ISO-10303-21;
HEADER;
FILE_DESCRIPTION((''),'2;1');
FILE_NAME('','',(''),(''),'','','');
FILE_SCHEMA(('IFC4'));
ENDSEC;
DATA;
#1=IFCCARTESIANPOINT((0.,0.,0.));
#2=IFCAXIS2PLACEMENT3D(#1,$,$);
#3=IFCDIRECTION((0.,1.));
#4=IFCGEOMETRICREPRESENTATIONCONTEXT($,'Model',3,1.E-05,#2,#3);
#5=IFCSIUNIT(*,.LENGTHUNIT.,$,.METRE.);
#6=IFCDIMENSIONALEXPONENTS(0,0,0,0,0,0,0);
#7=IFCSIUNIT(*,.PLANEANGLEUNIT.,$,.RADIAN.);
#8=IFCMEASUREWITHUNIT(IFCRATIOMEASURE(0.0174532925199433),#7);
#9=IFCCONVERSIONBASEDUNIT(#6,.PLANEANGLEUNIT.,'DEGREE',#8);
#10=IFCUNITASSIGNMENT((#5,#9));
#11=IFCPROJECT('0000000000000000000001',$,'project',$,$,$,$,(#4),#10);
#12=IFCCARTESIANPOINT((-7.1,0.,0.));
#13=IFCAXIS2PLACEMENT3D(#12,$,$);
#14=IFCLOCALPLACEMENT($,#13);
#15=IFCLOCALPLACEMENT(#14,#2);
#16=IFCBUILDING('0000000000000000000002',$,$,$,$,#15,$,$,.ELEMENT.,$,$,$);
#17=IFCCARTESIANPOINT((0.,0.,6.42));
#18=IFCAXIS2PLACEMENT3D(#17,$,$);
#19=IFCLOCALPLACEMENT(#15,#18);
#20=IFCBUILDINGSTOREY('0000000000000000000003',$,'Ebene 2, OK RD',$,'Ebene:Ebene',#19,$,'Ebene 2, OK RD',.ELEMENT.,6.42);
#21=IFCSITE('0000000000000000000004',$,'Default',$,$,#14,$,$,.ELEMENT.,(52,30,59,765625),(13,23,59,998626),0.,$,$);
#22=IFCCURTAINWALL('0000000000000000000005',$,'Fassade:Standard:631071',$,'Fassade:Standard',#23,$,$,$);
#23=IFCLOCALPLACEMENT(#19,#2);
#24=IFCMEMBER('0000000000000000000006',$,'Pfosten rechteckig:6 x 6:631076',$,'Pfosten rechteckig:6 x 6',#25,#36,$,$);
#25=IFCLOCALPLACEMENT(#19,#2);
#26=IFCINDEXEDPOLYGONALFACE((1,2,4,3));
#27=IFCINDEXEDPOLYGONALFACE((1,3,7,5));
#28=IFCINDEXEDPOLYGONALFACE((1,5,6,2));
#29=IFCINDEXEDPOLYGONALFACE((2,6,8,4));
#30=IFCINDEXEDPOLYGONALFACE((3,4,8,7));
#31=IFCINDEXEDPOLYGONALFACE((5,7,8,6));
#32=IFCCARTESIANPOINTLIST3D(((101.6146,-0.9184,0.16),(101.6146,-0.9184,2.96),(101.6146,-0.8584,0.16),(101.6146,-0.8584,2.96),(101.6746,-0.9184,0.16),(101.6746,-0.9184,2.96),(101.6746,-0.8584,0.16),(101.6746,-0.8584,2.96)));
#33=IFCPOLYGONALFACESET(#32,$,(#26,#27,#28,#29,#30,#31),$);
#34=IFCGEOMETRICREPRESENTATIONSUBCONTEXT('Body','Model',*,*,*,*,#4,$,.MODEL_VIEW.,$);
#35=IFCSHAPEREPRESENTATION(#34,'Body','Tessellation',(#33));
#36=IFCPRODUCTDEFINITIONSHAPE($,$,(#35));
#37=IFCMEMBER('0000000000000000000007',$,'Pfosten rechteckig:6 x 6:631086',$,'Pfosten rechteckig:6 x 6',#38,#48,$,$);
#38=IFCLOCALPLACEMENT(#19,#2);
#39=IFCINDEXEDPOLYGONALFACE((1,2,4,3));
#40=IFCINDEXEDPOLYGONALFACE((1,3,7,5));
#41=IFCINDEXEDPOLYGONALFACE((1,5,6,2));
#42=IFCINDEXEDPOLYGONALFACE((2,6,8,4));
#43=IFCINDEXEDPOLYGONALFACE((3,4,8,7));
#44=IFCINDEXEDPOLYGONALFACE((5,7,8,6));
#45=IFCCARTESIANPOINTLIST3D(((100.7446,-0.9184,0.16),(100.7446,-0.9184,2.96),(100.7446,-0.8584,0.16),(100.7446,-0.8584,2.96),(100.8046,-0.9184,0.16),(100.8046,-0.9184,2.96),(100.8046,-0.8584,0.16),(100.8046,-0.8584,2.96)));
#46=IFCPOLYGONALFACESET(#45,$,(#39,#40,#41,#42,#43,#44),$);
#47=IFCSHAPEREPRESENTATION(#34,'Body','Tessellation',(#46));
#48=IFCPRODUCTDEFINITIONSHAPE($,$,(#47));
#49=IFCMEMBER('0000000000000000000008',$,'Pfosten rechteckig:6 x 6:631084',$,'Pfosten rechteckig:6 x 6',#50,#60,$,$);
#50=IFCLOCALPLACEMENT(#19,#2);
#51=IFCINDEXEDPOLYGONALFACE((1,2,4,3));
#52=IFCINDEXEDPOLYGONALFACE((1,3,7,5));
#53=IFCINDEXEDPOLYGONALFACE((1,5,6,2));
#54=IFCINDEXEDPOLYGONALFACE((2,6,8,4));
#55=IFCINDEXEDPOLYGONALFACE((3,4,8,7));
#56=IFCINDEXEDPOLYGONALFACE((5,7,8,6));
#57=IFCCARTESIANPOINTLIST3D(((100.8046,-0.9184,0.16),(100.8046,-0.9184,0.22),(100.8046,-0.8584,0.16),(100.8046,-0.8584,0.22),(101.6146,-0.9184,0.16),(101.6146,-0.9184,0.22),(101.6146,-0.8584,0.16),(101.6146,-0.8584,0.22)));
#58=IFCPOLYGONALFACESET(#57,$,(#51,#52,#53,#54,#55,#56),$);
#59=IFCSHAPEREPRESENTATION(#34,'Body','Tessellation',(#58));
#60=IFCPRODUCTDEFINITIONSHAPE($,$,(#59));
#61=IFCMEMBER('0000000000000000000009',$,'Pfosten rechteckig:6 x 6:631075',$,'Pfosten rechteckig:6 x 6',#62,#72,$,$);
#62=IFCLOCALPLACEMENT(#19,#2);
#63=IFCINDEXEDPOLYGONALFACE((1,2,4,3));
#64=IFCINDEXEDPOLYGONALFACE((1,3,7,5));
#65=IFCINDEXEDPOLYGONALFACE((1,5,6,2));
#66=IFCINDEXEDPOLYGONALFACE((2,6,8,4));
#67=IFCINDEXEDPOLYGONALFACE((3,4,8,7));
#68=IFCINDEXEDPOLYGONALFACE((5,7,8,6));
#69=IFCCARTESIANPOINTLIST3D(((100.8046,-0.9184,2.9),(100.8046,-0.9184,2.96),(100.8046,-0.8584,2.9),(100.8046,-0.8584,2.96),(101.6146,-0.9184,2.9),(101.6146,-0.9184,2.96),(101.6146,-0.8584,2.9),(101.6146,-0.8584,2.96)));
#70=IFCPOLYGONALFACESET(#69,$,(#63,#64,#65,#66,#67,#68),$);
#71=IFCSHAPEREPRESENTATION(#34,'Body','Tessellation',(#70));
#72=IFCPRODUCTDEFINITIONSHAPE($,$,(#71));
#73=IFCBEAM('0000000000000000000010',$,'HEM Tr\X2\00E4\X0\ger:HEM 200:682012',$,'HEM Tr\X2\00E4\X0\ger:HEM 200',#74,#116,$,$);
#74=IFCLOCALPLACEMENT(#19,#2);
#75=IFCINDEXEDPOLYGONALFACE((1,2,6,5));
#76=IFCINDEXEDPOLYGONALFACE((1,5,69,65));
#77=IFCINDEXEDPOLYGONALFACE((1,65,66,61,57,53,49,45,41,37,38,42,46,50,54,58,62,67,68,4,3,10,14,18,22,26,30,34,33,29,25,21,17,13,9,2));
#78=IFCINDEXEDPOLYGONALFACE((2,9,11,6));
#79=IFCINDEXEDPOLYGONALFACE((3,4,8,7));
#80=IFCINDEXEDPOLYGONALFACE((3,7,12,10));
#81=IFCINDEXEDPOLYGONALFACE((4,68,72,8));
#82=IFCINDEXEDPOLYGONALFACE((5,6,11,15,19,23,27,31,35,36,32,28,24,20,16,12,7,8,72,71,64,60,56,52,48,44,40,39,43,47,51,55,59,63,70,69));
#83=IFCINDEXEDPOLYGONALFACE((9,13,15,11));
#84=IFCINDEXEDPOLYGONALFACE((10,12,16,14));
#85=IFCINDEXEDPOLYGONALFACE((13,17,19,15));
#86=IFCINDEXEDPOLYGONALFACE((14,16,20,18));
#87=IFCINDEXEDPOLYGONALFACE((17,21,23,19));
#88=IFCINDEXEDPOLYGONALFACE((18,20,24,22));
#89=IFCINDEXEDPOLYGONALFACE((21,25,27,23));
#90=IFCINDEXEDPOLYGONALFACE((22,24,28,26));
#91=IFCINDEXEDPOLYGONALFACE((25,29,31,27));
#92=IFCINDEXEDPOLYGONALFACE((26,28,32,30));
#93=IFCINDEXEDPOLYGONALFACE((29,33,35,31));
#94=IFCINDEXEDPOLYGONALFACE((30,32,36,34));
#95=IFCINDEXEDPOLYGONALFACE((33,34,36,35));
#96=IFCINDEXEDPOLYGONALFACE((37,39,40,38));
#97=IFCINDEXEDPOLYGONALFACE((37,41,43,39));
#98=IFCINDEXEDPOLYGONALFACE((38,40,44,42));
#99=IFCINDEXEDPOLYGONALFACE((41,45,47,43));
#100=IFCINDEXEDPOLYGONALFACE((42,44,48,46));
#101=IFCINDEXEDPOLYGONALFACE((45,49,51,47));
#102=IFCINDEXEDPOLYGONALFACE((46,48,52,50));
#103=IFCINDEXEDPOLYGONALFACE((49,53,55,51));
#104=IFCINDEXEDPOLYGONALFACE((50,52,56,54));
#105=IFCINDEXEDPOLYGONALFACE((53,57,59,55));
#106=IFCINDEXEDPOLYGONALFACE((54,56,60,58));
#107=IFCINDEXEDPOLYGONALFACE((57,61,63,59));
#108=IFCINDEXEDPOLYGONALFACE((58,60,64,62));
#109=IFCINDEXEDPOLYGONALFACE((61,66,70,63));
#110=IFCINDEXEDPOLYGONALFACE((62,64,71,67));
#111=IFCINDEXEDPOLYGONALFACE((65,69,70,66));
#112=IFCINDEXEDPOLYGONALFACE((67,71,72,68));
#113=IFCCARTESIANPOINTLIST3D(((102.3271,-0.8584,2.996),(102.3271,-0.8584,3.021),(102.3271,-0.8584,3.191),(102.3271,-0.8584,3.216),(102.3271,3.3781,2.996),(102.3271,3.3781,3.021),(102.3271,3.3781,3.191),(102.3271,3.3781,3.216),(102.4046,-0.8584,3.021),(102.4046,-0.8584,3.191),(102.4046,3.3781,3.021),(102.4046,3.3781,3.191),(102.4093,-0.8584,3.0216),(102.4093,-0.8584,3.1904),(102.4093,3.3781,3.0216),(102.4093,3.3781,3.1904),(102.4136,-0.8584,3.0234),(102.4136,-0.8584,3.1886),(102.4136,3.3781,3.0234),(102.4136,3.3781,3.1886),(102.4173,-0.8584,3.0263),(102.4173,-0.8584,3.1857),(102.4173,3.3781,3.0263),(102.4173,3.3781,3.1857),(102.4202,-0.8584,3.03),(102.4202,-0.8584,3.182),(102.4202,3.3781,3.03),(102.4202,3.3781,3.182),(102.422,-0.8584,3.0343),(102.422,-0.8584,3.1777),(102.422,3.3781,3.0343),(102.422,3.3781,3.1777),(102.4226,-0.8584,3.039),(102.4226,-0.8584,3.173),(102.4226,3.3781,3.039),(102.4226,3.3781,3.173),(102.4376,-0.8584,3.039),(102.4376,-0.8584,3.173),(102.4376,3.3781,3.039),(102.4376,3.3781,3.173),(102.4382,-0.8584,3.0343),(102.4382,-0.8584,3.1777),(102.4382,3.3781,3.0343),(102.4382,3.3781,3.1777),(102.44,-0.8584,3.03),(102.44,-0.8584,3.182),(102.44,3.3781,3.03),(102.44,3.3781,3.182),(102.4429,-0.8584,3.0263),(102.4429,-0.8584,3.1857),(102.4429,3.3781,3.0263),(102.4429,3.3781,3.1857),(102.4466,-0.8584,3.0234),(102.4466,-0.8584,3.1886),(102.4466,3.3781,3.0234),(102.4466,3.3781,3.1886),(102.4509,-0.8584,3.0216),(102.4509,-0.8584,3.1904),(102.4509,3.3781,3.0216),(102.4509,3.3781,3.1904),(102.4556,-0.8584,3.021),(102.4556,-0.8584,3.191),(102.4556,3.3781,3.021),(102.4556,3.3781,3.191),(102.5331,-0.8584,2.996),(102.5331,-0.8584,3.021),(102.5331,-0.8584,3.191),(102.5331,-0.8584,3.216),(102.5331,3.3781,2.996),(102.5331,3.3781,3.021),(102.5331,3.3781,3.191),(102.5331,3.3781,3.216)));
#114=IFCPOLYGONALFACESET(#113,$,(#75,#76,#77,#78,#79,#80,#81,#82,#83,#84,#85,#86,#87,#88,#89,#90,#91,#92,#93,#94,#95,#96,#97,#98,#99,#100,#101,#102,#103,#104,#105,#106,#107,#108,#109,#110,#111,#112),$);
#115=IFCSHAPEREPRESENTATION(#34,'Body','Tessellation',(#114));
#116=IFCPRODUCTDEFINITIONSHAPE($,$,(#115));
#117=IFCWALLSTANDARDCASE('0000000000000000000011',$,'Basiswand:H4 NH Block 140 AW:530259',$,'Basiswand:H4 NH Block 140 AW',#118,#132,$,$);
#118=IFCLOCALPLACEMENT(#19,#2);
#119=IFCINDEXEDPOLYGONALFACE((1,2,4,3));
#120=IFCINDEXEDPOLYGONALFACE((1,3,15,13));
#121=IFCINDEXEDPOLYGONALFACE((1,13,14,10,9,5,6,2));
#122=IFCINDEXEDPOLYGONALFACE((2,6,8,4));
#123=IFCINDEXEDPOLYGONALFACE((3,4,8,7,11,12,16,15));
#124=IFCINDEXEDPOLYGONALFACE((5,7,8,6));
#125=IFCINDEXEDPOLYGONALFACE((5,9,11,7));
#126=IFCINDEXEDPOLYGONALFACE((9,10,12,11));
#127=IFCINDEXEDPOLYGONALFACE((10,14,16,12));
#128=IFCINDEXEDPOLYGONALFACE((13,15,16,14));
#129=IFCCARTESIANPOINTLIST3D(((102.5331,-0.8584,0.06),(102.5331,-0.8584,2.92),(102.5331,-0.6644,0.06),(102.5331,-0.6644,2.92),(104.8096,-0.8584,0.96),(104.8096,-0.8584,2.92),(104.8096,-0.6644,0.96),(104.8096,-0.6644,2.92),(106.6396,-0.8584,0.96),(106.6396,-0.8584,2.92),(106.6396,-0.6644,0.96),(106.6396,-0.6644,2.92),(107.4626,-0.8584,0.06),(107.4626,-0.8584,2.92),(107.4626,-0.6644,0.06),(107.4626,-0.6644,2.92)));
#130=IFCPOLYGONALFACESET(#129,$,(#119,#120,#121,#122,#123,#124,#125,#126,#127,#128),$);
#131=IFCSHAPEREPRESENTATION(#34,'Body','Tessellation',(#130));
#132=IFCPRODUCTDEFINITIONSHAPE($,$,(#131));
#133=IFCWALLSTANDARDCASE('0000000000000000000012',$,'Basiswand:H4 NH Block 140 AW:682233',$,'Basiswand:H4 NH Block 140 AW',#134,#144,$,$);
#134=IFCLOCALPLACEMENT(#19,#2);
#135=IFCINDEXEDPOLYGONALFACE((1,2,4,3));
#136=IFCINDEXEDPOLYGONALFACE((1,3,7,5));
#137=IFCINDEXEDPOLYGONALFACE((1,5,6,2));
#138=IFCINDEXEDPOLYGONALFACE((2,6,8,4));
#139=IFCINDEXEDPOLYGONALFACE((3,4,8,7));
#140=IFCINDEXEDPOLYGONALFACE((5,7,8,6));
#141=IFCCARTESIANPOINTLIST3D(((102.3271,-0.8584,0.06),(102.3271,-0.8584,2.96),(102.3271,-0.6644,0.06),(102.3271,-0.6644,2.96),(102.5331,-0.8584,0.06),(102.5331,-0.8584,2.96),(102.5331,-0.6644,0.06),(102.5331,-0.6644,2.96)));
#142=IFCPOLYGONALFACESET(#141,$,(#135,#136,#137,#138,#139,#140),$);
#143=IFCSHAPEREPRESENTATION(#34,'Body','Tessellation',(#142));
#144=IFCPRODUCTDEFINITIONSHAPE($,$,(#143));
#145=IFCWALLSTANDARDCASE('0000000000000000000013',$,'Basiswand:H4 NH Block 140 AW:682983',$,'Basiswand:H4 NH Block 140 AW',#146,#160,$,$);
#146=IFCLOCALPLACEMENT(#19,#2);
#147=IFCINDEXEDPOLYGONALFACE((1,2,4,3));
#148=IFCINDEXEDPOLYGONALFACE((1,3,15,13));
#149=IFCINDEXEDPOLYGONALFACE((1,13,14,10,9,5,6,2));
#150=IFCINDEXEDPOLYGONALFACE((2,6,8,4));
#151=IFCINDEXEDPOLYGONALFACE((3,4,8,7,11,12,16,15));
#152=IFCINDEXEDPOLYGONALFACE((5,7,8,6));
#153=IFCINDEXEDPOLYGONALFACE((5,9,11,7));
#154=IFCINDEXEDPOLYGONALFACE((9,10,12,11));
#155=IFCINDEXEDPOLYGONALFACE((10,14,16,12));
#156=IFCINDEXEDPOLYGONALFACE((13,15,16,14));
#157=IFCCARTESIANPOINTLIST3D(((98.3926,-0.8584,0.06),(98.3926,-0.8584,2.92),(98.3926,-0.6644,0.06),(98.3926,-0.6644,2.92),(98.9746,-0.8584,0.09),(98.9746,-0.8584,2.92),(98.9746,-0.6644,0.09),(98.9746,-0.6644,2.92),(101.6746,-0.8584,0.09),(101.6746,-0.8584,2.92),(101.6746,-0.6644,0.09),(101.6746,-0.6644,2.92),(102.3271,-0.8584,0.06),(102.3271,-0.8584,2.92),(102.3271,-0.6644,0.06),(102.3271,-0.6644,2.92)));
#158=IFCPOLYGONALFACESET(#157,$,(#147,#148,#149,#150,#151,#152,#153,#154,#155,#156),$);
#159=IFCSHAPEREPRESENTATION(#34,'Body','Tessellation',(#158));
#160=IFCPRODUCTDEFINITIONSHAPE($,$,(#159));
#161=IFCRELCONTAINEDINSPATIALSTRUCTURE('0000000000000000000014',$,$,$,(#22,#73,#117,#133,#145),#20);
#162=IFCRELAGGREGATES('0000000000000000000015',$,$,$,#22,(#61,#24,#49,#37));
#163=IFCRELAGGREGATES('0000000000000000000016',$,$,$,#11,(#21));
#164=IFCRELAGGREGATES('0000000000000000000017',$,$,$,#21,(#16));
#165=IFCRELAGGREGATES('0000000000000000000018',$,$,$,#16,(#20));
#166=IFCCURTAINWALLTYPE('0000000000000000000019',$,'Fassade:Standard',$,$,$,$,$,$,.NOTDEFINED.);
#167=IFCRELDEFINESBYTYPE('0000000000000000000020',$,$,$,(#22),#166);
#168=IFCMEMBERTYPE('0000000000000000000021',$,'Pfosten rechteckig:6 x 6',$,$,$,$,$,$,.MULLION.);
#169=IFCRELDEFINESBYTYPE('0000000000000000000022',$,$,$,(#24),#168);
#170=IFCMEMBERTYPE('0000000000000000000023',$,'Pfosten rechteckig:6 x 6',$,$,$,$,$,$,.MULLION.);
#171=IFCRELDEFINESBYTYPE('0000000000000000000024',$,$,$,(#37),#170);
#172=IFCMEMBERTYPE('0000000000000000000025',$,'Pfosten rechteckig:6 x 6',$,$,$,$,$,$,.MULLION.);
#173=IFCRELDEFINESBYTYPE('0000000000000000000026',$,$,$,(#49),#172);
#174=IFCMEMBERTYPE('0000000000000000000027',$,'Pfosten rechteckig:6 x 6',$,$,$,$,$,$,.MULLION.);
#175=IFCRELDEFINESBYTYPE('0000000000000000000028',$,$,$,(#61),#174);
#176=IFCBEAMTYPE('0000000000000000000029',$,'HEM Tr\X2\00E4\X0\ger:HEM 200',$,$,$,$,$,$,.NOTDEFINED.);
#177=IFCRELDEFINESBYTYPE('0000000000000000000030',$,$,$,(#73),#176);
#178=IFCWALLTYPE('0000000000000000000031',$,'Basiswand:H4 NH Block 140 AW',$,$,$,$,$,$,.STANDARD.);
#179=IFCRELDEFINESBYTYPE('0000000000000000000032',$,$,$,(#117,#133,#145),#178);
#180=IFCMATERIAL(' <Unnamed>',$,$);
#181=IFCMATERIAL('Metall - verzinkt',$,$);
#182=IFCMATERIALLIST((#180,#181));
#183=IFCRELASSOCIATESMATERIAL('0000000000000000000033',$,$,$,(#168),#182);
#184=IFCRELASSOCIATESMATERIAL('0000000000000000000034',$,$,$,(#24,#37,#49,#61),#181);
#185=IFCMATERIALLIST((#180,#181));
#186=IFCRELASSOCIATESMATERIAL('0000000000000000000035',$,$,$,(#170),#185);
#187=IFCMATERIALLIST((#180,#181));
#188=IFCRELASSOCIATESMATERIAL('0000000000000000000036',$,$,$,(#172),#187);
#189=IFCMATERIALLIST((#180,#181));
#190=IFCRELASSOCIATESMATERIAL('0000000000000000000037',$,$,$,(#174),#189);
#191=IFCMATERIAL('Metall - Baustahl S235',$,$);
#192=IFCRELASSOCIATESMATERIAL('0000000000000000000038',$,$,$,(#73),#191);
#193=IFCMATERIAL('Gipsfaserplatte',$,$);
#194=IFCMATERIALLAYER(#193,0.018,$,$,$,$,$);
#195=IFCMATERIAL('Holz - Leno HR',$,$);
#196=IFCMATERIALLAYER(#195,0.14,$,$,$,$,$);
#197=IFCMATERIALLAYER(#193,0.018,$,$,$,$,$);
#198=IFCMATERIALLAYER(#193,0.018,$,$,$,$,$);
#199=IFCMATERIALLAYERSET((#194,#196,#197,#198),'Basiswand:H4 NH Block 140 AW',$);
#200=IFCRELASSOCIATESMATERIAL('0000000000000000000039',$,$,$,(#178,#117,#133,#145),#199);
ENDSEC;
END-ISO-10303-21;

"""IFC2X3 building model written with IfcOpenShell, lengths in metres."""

from ifc_helpers import new_model, entity, si_unit, converted_unit, direction, frame, frame_2d, origin, origin_2d_with_axis, place, context, subcontext, project, spatial, rectangle, i_section, extrude, source, transform, mapped, material, material_list, layer, layer_set, layer_usage, type_object, type_shapes, element, aggregate, save


model = new_model("IFC2X3")

# Units and contexts
model_context = context("Model", 3, precision=1e-05, world=origin(), true_north=direction((0.0, 1.0)))
body_context = subcontext(model_context, "Body", "Model", "MODEL_VIEW")
ifc_project = project(units=[si_unit("LENGTHUNIT", "METRE"), converted_unit("PLANEANGLEUNIT", "DEGREE", entity("IfcRatioMeasure", 0.0174532925199433), si_unit("PLANEANGLEUNIT", "RADIAN"), dimensions=[0, 0, 0, 0, 0, 0, 0])], contexts=[model_context])

# Site, building, storey
site_placement = place(None, frame((-7.1, 0.0, 0.0)))
site = spatial("IfcSite", under=ifc_project, at=site_placement, Name="Default", CompositionType="ELEMENT", RefLatitude=(52, 30, 59, 765625), RefLongitude=(13, 23, 59, 998626), RefElevation=0.0)
building_placement = place(site_placement, origin())
building = spatial("IfcBuilding", under=site, at=building_placement, CompositionType="ELEMENT")
storey_placement = place(building_placement, frame((0.0, 0.0, 6.42)))
storey = spatial("IfcBuildingStorey", under=building, at=storey_placement, Name="Ebene 2, OK RD", ObjectType="Ebene:Ebene", LongName="Ebene 2, OK RD", CompositionType="ELEMENT", Elevation=6.42)

# Curtain wall, members
curtain_wall_type = type_object("IfcCurtainWallType", Name="Fassade:Standard", PredefinedType="NOTDEFINED")
curtain_wall_placement = place(storey_placement, frame((0.0, 0.0, -6.42)))
curtain_wall = element("IfcCurtainWall", 1, at=curtain_wall_placement, inside=storey, type_object=curtain_wall_type, Name="Fassade:Standard:631071", ObjectType="Fassade:Standard")
ifc_material_1 = material(Name="Metall - verzinkt")
ifc_material_2 = material(Name=" <Unnamed>")
ifc_material_list_1 = material_list([ifc_material_2, ifc_material_1])
member_type_1 = type_object("IfcMemberType", Name="Pfosten rechteckig:6 x 6", PredefinedType="MULLION", material=ifc_material_list_1)
shared_shape_1 = source(origin(), body_context, "Body", "SweptSolid", [
    extrude(rectangle(XDim=0.06, YDim=0.06, at=origin_2d_with_axis()), frame((-0.03, 0.0, -2.8), z_axis=(0.0, 0.0, 1.0), x_axis=(0.0, -1.0, 0.0)), (0.0, 0.0, 1.0), 2.8),
])
type_shapes(member_type_1, [shared_shape_1])
placement = place(building_placement, frame((0.0, 0.0, 3.26)))
member_1_placement = place(placement, frame((101.6746, -0.8884, 3.32), z_axis=(0.0, 0.0, -1.0), x_axis=(1.0, 0.0, 0.0)))
member_1 = element("IfcMember", 2, at=member_1_placement, type_object=member_type_1, material=ifc_material_1, Name="Pfosten rechteckig:6 x 6:631076", ObjectType="Pfosten rechteckig:6 x 6", context=body_context, shape_type="MappedRepresentation", body=[
    mapped(shared_shape_1, transform((0.0, 0.0, 0.0), scale=1.0)),
])
ifc_material_list_2 = material_list([ifc_material_2, ifc_material_1])
member_type_2 = type_object("IfcMemberType", Name="Pfosten rechteckig:6 x 6", PredefinedType="MULLION", material=ifc_material_list_2)
shared_shape_2 = source(origin(), body_context, "Body", "SweptSolid", [
    extrude(rectangle(XDim=0.06, YDim=0.06, at=origin_2d_with_axis()), frame((0.0, 0.0, -2.8), z_axis=(0.0, 0.0, 1.0), x_axis=(0.0, -1.0, 0.0)), (0.0, 0.0, 1.0), 2.8),
])
type_shapes(member_type_2, [shared_shape_2])
member_2_placement = place(placement, frame((100.7746, -0.8884, 3.32), z_axis=(0.0, 0.0, -1.0), x_axis=(1.0, 0.0, 0.0)))
member_2 = element("IfcMember", 3, at=member_2_placement, type_object=member_type_2, material=ifc_material_1, Name="Pfosten rechteckig:6 x 6:631086", ObjectType="Pfosten rechteckig:6 x 6", context=body_context, shape_type="MappedRepresentation", body=[
    mapped(shared_shape_2, transform((0.0, 0.0, 0.0), scale=1.0)),
])
ifc_material_list_3 = material_list([ifc_material_2, ifc_material_1])
member_type_3 = type_object("IfcMemberType", Name="Pfosten rechteckig:6 x 6", PredefinedType="MULLION", material=ifc_material_list_3)
shared_shape_3 = source(origin(), body_context, "Body", "SweptSolid", [
    extrude(rectangle(XDim=0.06, YDim=0.06, at=origin_2d_with_axis()), frame((-0.03, 0.0, -0.81), z_axis=(0.0, 0.0, 1.0), x_axis=(0.0, -1.0, 0.0)), (0.0, 0.0, 1.0), 0.81),
])
type_shapes(member_type_3, [shared_shape_3])
member_3_placement = place(placement, frame((100.8046, -0.8884, 3.32), z_axis=(-1.0, 0.0, 0.0), x_axis=(0.0, 0.0, -1.0)))
member_3 = element("IfcMember", 4, at=member_3_placement, type_object=member_type_3, material=ifc_material_1, Name="Pfosten rechteckig:6 x 6:631084", ObjectType="Pfosten rechteckig:6 x 6", context=body_context, shape_type="MappedRepresentation", body=[
    mapped(shared_shape_3, transform((0.0, 0.0, 0.0), scale=1.0)),
])
ifc_material_list_4 = material_list([ifc_material_2, ifc_material_1])
member_type_4 = type_object("IfcMemberType", Name="Pfosten rechteckig:6 x 6", PredefinedType="MULLION", material=ifc_material_list_4)
shared_shape_4 = source(origin(), body_context, "Body", "SweptSolid", [
    extrude(rectangle(XDim=0.06, YDim=0.06, at=origin_2d_with_axis()), frame((-0.03, 0.0, -0.81), z_axis=(0.0, 0.0, 1.0), x_axis=(0.0, -1.0, 0.0)), (0.0, 0.0, 1.0), 0.81),
])
type_shapes(member_type_4, [shared_shape_4])
member_4_placement = place(placement, frame((101.6146, -0.8884, 6.12), z_axis=(1.0, 0.0, 0.0), x_axis=(0.0, 0.0, 1.0)))
member_4 = element("IfcMember", 5, at=member_4_placement, type_object=member_type_4, material=ifc_material_1, Name="Pfosten rechteckig:6 x 6:631075", ObjectType="Pfosten rechteckig:6 x 6", context=body_context, shape_type="MappedRepresentation", body=[
    mapped(shared_shape_4, transform((0.0, 0.0, 0.0), scale=1.0)),
])

# Beam
ifc_material_3 = material(Name="Metall - Baustahl S235")
beam_type = type_object("IfcBeamType", Name="HEM Träger:HEM 200", PredefinedType="NOTDEFINED")
beam_placement = place(storey_placement, frame((102.4301, -0.8404, 2.996), z_axis=(0.0, 0.0, 1.0), x_axis=(0.0, 1.0, 0.0)))
element("IfcBeam", 6, at=beam_placement, inside=storey, type_object=beam_type, material=ifc_material_3, Name="HEM Träger:HEM 200:682012", ObjectType="HEM Träger:HEM 200", context=body_context, shape_type="SweptSolid", body=[
    extrude(i_section(OverallWidth=0.206, OverallDepth=0.22, WebThickness=0.015, FlangeThickness=0.025, FilletRadius=0.018, at=frame_2d((0.0, 0.0), x_axis=(0.0, 1.0))), frame((-0.018, 0.0, 0.11), z_axis=(1.0, 0.0, 0.0), x_axis=(0.0, 0.0, -1.0)), (0.0, 0.0, 1.0), 4.2365),
])

aggregate(curtain_wall, [member_4, member_1, member_3, member_2])

# Wall, opening
ifc_material_4 = material(Name="Gipsfaserplatte")
ifc_layer_1 = layer(ifc_material_4, 0.018)
ifc_material_5 = material(Name="Holz - Leno HR")
ifc_layer_2 = layer(ifc_material_5, 0.14)
ifc_layer_3 = layer(ifc_material_4, 0.018)
ifc_layer_4 = layer(ifc_material_4, 0.018)
ifc_layer_set_1 = layer_set([ifc_layer_1, ifc_layer_2, ifc_layer_3, ifc_layer_4], Name="Basiswand:H4 NH Block 140 AW")
ifc_layer_usage_1 = layer_usage(ifc_layer_set_1, "AXIS2", "NEGATIVE", 0.097)
wall_type_1 = type_object("IfcWallType", Name="Basiswand:H4 NH Block 140 AW", PredefinedType="STANDARD", material=ifc_layer_set_1)
wall_1_placement = place(storey_placement, frame((107.4626, -0.7614, 0.06), z_axis=(0.0, 0.0, 1.0), x_axis=(-1.0, 0.0, 0.0)))
wall_1 = element("IfcWallStandardCase", 7, at=wall_1_placement, inside=storey, type_object=wall_type_1, material=ifc_layer_usage_1, Name="Basiswand:H4 NH Block 140 AW:530259", ObjectType="Basiswand:H4 NH Block 140 AW", context=body_context, shape_type="SweptSolid", body=[
    extrude(rectangle(XDim=4.9295, YDim=0.194, at=frame_2d((2.4648, 0.0), x_axis=(-1.0, 0.0))), origin(), (0.0, 0.0, 1.0), 2.86),
])
opening_1_placement = place(wall_1_placement, origin())
element("IfcOpeningElement", 8, at=opening_1_placement, cuts=wall_1, ObjectType="Opening", context=body_context, shape_type="SweptSolid", body=[
    extrude(rectangle(XDim=2.0, YDim=1.83, at=frame_2d((0.0, 0.0), x_axis=(1.0, 0.0))), frame((1.738, -0.097, 1.9), z_axis=(0.0, 1.0, 0.0), x_axis=(0.0, 0.0, -1.0)), (0.0, 0.0, 1.0), 0.194),
])

# Wall
ifc_layer_usage_2 = layer_usage(ifc_layer_set_1, "AXIS2", "NEGATIVE", 0.097)
wall_2_placement = place(storey_placement, frame((102.5331, -0.7614, 0.06), z_axis=(0.0, 0.0, 1.0), x_axis=(-1.0, 0.0, 0.0)))
element("IfcWallStandardCase", 9, at=wall_2_placement, inside=storey, type_object=wall_type_1, material=ifc_layer_usage_2, Name="Basiswand:H4 NH Block 140 AW:682233", ObjectType="Basiswand:H4 NH Block 140 AW", context=body_context, shape_type="SweptSolid", body=[
    extrude(rectangle(XDim=0.206, YDim=0.194, at=frame_2d((0.103, 0.0), x_axis=(-1.0, 0.0))), origin(), (0.0, 0.0, 1.0), 2.9),
])

# Wall, opening
ifc_layer_usage_3 = layer_usage(ifc_layer_set_1, "AXIS2", "NEGATIVE", 0.097)
wall_3_placement = place(storey_placement, frame((102.3271, -0.7614, 0.06), z_axis=(0.0, 0.0, 1.0), x_axis=(-1.0, 0.0, 0.0)))
wall_3 = element("IfcWallStandardCase", 10, at=wall_3_placement, inside=storey, type_object=wall_type_1, material=ifc_layer_usage_3, Name="Basiswand:H4 NH Block 140 AW:682983", ObjectType="Basiswand:H4 NH Block 140 AW", context=body_context, shape_type="SweptSolid", body=[
    extrude(rectangle(XDim=3.9345, YDim=0.194, at=frame_2d((1.9672, 0.0), x_axis=(-1.0, 0.0))), origin(), (0.0, 0.0, 1.0), 2.86),
])
opening_2_placement = place(wall_3_placement, origin())
element("IfcOpeningElement", 11, at=opening_2_placement, cuts=wall_3, ObjectType="Opening", context=body_context, shape_type="SweptSolid", body=[
    extrude(rectangle(XDim=2.87, YDim=2.7, at=frame_2d((0.0, 0.0), x_axis=(1.0, 0.0))), frame((2.0025, -0.097, 1.465), z_axis=(0.0, 1.0, 0.0), x_axis=(0.0, 0.0, -1.0)), (0.0, 0.0, 1.0), 0.194),
])

save(model, "model.ifc")
